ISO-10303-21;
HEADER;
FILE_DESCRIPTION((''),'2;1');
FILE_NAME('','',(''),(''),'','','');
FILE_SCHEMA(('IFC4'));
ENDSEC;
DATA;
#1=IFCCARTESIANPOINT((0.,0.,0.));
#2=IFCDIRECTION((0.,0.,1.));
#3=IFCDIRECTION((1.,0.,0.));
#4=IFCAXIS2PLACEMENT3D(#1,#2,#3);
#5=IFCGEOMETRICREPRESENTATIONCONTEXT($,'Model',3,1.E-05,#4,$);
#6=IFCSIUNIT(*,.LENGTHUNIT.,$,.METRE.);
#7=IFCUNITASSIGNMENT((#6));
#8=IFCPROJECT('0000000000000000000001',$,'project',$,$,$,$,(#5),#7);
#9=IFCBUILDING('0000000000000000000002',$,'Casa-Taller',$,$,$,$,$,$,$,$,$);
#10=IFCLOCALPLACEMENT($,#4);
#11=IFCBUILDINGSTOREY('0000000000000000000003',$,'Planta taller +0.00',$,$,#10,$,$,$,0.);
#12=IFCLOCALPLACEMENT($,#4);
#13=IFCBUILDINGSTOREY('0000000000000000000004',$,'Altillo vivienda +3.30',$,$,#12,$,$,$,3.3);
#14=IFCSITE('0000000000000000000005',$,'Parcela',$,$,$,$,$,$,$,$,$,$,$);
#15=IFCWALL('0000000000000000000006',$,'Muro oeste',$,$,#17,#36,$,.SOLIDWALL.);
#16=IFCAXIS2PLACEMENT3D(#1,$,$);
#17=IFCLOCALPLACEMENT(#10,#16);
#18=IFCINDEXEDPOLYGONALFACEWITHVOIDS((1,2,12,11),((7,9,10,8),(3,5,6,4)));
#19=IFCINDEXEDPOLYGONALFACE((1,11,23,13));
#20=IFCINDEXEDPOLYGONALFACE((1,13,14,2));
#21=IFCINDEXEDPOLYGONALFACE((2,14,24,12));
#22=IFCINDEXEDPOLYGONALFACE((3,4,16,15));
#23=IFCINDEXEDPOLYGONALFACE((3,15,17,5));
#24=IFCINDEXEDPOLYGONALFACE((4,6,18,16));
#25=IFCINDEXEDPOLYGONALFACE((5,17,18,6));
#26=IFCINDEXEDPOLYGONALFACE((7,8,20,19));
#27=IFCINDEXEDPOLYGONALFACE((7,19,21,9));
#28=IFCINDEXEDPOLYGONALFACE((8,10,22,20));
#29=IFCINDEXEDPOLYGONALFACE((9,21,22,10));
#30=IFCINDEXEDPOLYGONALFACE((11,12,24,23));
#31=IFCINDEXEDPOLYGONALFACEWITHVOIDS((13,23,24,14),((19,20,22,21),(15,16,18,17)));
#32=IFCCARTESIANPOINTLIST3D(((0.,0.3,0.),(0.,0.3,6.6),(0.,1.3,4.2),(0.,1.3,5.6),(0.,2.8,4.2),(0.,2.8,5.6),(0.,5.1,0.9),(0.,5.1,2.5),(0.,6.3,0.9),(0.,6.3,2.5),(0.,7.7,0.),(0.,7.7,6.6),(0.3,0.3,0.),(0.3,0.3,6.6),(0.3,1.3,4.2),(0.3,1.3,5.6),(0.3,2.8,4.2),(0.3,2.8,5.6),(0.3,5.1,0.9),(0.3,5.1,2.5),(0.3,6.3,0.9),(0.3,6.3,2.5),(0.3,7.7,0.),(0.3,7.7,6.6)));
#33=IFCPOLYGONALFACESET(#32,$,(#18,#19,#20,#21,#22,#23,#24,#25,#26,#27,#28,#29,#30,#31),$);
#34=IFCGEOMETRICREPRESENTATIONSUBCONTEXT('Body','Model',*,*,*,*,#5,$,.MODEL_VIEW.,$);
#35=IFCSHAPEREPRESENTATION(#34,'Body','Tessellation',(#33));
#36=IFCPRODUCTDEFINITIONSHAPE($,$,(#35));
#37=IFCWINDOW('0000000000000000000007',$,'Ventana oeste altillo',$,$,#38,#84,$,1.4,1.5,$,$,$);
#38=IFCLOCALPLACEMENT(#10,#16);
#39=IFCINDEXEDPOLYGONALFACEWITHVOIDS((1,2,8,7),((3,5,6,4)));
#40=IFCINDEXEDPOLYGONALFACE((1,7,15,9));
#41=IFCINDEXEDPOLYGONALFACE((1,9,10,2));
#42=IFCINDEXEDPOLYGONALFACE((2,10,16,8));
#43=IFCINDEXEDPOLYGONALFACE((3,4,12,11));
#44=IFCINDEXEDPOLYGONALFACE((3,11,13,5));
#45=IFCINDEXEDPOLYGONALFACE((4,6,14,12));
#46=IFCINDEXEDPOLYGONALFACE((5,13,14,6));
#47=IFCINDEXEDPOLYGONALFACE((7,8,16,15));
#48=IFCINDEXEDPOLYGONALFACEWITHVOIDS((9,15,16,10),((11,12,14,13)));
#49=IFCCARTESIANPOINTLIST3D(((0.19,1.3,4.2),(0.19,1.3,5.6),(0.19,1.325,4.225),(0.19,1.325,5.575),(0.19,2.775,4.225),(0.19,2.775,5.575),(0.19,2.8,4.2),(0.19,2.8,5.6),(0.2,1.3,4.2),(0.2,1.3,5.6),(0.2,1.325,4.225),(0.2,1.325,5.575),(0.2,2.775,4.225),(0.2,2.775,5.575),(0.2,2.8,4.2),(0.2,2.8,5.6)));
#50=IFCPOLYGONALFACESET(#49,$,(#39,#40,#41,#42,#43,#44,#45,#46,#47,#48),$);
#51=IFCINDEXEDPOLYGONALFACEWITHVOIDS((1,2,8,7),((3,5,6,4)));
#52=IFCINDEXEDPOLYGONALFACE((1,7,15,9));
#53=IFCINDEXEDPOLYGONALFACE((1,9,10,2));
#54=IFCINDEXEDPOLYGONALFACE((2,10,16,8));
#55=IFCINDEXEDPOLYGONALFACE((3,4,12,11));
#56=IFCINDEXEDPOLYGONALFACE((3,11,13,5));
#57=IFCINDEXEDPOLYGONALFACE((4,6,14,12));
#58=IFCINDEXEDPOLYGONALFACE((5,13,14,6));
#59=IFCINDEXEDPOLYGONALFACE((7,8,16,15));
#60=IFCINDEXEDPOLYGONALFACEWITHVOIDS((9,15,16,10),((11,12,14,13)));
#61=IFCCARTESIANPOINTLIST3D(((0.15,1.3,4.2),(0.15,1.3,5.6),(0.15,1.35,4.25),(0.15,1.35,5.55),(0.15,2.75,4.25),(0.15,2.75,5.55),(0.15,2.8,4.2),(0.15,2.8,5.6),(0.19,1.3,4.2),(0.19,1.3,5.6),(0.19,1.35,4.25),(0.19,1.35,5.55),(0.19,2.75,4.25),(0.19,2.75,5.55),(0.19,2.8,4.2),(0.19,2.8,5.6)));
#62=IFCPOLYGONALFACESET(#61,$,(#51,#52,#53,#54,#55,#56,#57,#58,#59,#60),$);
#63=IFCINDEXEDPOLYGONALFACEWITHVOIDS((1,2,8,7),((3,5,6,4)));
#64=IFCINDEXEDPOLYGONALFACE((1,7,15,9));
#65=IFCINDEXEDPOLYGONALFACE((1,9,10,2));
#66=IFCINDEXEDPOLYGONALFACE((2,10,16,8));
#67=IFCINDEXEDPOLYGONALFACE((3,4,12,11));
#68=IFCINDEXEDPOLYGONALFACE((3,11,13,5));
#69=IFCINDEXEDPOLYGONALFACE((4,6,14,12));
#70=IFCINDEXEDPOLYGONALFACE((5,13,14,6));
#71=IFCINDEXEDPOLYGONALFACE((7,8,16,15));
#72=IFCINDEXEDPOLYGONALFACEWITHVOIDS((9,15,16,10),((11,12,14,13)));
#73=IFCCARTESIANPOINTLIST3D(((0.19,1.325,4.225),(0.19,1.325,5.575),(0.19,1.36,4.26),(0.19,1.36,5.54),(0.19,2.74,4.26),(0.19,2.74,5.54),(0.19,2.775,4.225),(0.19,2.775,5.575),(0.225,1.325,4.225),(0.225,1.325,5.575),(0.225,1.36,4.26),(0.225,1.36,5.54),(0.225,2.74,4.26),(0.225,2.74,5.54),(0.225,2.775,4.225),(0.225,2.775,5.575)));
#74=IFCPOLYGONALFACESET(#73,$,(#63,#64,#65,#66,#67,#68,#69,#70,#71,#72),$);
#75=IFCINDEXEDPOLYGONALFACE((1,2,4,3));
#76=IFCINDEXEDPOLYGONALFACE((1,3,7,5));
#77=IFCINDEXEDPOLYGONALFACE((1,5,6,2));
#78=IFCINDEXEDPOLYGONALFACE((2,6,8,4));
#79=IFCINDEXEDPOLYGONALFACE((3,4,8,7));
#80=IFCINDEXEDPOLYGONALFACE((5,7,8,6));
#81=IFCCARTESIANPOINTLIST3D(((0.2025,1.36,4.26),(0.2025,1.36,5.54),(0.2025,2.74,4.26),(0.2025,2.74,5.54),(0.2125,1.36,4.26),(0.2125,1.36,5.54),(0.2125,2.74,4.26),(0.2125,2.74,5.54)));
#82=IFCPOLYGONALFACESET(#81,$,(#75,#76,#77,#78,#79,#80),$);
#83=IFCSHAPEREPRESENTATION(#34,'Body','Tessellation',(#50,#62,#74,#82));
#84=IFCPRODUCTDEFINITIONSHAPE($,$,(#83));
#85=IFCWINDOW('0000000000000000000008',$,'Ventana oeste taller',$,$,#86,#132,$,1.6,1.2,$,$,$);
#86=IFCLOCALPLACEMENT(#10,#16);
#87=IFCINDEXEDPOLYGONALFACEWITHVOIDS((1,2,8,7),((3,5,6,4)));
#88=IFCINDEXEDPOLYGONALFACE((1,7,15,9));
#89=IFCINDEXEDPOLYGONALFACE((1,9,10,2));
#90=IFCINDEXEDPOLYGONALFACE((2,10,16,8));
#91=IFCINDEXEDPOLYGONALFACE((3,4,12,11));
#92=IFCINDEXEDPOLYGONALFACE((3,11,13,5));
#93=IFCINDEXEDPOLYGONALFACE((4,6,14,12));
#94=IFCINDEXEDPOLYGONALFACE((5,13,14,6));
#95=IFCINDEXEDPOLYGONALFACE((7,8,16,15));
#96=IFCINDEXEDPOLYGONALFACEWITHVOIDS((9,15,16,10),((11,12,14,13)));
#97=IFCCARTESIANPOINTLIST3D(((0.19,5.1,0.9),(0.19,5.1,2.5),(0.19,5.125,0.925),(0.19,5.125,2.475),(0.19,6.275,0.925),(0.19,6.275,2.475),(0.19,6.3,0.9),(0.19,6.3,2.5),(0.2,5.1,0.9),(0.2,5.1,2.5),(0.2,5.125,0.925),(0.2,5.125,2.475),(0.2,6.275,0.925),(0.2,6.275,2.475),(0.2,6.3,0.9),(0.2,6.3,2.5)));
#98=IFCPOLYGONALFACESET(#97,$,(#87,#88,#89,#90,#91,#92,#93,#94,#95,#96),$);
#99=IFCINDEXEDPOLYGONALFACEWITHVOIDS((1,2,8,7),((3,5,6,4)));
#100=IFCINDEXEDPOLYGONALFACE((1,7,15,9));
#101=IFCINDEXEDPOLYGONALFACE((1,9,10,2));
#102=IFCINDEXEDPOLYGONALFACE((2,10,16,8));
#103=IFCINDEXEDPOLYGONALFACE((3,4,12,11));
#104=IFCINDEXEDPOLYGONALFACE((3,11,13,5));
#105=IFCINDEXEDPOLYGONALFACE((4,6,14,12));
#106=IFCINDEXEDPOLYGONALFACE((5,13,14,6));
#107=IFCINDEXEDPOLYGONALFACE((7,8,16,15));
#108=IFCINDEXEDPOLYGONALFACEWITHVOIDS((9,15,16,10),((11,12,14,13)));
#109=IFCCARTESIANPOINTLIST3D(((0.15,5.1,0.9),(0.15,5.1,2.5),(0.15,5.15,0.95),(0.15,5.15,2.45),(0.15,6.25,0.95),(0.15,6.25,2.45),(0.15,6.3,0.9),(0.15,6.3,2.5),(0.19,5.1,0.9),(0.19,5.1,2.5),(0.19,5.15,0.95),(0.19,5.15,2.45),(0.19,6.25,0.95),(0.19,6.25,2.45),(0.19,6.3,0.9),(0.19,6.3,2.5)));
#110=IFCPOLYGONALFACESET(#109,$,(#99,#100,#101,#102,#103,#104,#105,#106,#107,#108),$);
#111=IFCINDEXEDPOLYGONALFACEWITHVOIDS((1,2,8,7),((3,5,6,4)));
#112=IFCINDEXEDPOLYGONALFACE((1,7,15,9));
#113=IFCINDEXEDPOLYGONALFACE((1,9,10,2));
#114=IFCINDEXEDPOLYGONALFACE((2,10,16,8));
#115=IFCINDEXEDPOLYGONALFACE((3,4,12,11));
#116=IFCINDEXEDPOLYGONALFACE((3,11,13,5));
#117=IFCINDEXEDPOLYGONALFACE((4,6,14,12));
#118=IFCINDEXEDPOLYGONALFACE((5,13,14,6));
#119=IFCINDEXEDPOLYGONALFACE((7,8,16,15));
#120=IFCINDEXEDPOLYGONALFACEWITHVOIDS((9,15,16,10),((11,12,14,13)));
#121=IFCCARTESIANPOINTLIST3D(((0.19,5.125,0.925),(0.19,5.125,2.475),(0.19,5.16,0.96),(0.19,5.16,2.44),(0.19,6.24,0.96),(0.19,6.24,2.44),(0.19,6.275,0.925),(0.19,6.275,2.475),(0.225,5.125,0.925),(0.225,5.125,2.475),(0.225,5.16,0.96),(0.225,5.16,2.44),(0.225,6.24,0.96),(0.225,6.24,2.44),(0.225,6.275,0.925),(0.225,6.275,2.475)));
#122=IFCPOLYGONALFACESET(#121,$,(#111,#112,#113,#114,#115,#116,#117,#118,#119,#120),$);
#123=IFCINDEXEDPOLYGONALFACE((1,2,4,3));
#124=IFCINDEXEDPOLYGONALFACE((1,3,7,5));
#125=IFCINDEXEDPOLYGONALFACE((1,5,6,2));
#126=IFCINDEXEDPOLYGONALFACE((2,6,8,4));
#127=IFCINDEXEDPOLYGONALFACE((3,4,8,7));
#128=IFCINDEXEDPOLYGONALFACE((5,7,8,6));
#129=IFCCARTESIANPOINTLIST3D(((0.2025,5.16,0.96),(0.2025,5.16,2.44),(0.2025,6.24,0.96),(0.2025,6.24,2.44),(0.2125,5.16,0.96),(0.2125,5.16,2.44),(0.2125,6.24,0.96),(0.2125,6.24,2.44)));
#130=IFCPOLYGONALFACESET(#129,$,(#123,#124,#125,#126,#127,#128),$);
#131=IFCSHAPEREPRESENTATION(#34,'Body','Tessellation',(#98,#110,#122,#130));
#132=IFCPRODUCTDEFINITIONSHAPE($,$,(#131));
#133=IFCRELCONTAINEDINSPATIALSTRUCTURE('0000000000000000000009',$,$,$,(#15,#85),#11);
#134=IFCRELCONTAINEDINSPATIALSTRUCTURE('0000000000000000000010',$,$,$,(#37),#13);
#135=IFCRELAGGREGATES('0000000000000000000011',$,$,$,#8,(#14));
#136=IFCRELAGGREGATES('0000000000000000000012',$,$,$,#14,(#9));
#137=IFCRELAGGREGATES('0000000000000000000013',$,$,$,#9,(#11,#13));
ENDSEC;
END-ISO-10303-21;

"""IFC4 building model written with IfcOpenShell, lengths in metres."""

from ifc_helpers import new_model, si_unit, frame, origin_with_axes, place, context, subcontext, project, spatial, line, indexed_curve, outline, extrude, element, fill, save


model = new_model("IFC4")

# Units and contexts
model_context = context("Model", 3, precision=1e-05, world=origin_with_axes())
body_context = subcontext(model_context, "Body", "Model", "MODEL_VIEW")
ifc_project = project(units=[si_unit("LENGTHUNIT", "METRE")], contexts=[model_context])

# Site, building, storey
site = spatial("IfcSite", under=ifc_project, Name="Parcela")
building = spatial("IfcBuilding", under=site, Name="Casa-Taller")
storey_1_placement = place(None, origin_with_axes())
storey_1 = spatial("IfcBuildingStorey", under=building, at=storey_1_placement, Name="Planta taller +0.00", Elevation=0.0)

# Shared definitions
storey_2_placement = place(None, origin_with_axes())
storey_2 = spatial("IfcBuildingStorey", under=building, at=storey_2_placement, Name="Altillo vivienda +3.30", Elevation=3.3)

# Wall, openings, windows
wall_1_placement = place(storey_1_placement, frame((0.0, 7.7, 0.0), z_axis=(0.0, 0.0, 1.0), x_axis=(0.0, -1.0, 0.0)))
wall_1 = element("IfcWall", 1, at=wall_1_placement, inside=storey_1, Name="Muro oeste", PredefinedType="SOLIDWALL", context=body_context, shape_type="SweptSolid", body=[
    extrude(outline(indexed_curve([(0.0, 0.0), (0.0, 0.3), (7.4, 0.3), (7.4, 0.0), (0.0, 0.0)], self_intersect=False)), origin_with_axes(), (0.0, 0.0, 1.0), 6.6),
])
opening_1_placement = place(wall_1_placement, frame((4.9, -0.1, 4.2), z_axis=(0.0, 0.0, 1.0), x_axis=(1.0, 0.0, 0.0)))
opening_1 = element("IfcOpeningElement", 2, at=opening_1_placement, cuts=wall_1, context=body_context, shape_type="SweptSolid", body=[
    extrude(outline(indexed_curve([(0.0, 0.0), (0.0, 0.5), (1.5, 0.5), (1.5, 0.0), (0.0, 0.0)], self_intersect=False)), origin_with_axes(), (0.0, 0.0, 1.0), 1.4),
])
opening_2_placement = place(wall_1_placement, frame((1.4, -0.1, 0.9), z_axis=(0.0, 0.0, 1.0), x_axis=(1.0, 0.0, 0.0)))
opening_2 = element("IfcOpeningElement", 3, at=opening_2_placement, cuts=wall_1, context=body_context, shape_type="SweptSolid", body=[
    extrude(outline(indexed_curve([(0.0, 0.0), (0.0, 0.5), (1.2, 0.5), (1.2, 0.0), (0.0, 0.0)], self_intersect=False)), origin_with_axes(), (0.0, 0.0, 1.0), 1.6),
])
window_1_placement = place(opening_1_placement, frame((0.0, 0.2, 0.0), z_axis=(0.0, 0.0, 1.0), x_axis=(1.0, 0.0, 0.0)))
window_1 = element("IfcWindow", 4, at=window_1_placement, inside=storey_2, Name="Ventana oeste altillo", OverallHeight=1.4, OverallWidth=1.5, context=body_context, shape_type="SweptSolid", body=[
    extrude(outline(indexed_curve([(0.0, 0.0), (1.5, 0.0), (1.5, 1.4), (0.0, 1.4)], segments=[line(1, 2, 3, 4, 1)]), holes=[indexed_curve([(0.025, 0.025), (1.475, 0.025), (1.475, 1.375), (0.025, 1.375)], segments=[line(1, 2, 3, 4, 1)])]), frame((0.0, 0.09, 0.0), z_axis=(0.0, -1.0, 0.0), x_axis=(1.0, 0.0, 0.0)), (0.0, 0.0, -1.0), 0.01),
    extrude(outline(indexed_curve([(0.0, 0.0), (1.5, 0.0), (1.5, 1.4), (0.0, 1.4)], segments=[line(1, 2, 3, 4, 1)]), holes=[indexed_curve([(0.05, 0.05), (1.45, 0.05), (1.45, 1.35), (0.05, 1.35)], segments=[line(1, 2, 3, 4, 1)])]), frame((0.0, 0.05, 0.0), z_axis=(0.0, -1.0, 0.0), x_axis=(1.0, 0.0, 0.0)), (0.0, 0.0, -1.0), 0.04),
    extrude(outline(indexed_curve([(0.0, 0.0), (1.45, 0.0), (1.45, 1.35), (0.0, 1.35)], segments=[line(1, 2, 3, 4, 1)]), holes=[indexed_curve([(0.035, 0.035), (1.415, 0.035), (1.415, 1.315), (0.035, 1.315)], segments=[line(1, 2, 3, 4, 1)])]), frame((0.025, 0.09, 0.025), z_axis=(0.0, -1.0, 0.0), x_axis=(1.0, 0.0, 0.0)), (0.0, 0.0, -1.0), 0.035),
    extrude(outline(indexed_curve([(0.035, 0.035), (1.415, 0.035), (1.415, 1.315), (0.035, 1.315)], segments=[line(1, 2, 3, 4, 1)])), frame((0.025, 0.1025, 0.025), z_axis=(0.0, -1.0, 0.0), x_axis=(1.0, 0.0, 0.0)), (0.0, 0.0, -1.0), 0.01),
])
fill(opening_1, window_1)
window_2_placement = place(opening_2_placement, frame((0.0, 0.2, 0.0), z_axis=(0.0, 0.0, 1.0), x_axis=(1.0, 0.0, 0.0)))
window_2 = element("IfcWindow", 5, at=window_2_placement, inside=storey_1, Name="Ventana oeste taller", OverallHeight=1.6, OverallWidth=1.2, context=body_context, shape_type="SweptSolid", body=[
    extrude(outline(indexed_curve([(0.0, 0.0), (1.2, 0.0), (1.2, 1.6), (0.0, 1.6)], segments=[line(1, 2, 3, 4, 1)]), holes=[indexed_curve([(0.025, 0.025), (1.175, 0.025), (1.175, 1.575), (0.025, 1.575)], segments=[line(1, 2, 3, 4, 1)])]), frame((0.0, 0.09, 0.0), z_axis=(0.0, -1.0, 0.0), x_axis=(1.0, 0.0, 0.0)), (0.0, 0.0, -1.0), 0.01),
    extrude(outline(indexed_curve([(0.0, 0.0), (1.2, 0.0), (1.2, 1.6), (0.0, 1.6)], segments=[line(1, 2, 3, 4, 1)]), holes=[indexed_curve([(0.05, 0.05), (1.15, 0.05), (1.15, 1.55), (0.05, 1.55)], segments=[line(1, 2, 3, 4, 1)])]), frame((0.0, 0.05, 0.0), z_axis=(0.0, -1.0, 0.0), x_axis=(1.0, 0.0, 0.0)), (0.0, 0.0, -1.0), 0.04),
    extrude(outline(indexed_curve([(0.0, 0.0), (1.15, 0.0), (1.15, 1.55), (0.0, 1.55)], segments=[line(1, 2, 3, 4, 1)]), holes=[indexed_curve([(0.035, 0.035), (1.115, 0.035), (1.115, 1.515), (0.035, 1.515)], segments=[line(1, 2, 3, 4, 1)])]), frame((0.025, 0.09, 0.025), z_axis=(0.0, -1.0, 0.0), x_axis=(1.0, 0.0, 0.0)), (0.0, 0.0, -1.0), 0.035),
    extrude(outline(indexed_curve([(0.035, 0.035), (1.115, 0.035), (1.115, 1.515), (0.035, 1.515)], segments=[line(1, 2, 3, 4, 1)])), frame((0.025, 0.1025, 0.025), z_axis=(0.0, -1.0, 0.0), x_axis=(1.0, 0.0, 0.0)), (0.0, 0.0, -1.0), 0.01),
])
fill(opening_2, window_2)

save(model, "model.ifc")
